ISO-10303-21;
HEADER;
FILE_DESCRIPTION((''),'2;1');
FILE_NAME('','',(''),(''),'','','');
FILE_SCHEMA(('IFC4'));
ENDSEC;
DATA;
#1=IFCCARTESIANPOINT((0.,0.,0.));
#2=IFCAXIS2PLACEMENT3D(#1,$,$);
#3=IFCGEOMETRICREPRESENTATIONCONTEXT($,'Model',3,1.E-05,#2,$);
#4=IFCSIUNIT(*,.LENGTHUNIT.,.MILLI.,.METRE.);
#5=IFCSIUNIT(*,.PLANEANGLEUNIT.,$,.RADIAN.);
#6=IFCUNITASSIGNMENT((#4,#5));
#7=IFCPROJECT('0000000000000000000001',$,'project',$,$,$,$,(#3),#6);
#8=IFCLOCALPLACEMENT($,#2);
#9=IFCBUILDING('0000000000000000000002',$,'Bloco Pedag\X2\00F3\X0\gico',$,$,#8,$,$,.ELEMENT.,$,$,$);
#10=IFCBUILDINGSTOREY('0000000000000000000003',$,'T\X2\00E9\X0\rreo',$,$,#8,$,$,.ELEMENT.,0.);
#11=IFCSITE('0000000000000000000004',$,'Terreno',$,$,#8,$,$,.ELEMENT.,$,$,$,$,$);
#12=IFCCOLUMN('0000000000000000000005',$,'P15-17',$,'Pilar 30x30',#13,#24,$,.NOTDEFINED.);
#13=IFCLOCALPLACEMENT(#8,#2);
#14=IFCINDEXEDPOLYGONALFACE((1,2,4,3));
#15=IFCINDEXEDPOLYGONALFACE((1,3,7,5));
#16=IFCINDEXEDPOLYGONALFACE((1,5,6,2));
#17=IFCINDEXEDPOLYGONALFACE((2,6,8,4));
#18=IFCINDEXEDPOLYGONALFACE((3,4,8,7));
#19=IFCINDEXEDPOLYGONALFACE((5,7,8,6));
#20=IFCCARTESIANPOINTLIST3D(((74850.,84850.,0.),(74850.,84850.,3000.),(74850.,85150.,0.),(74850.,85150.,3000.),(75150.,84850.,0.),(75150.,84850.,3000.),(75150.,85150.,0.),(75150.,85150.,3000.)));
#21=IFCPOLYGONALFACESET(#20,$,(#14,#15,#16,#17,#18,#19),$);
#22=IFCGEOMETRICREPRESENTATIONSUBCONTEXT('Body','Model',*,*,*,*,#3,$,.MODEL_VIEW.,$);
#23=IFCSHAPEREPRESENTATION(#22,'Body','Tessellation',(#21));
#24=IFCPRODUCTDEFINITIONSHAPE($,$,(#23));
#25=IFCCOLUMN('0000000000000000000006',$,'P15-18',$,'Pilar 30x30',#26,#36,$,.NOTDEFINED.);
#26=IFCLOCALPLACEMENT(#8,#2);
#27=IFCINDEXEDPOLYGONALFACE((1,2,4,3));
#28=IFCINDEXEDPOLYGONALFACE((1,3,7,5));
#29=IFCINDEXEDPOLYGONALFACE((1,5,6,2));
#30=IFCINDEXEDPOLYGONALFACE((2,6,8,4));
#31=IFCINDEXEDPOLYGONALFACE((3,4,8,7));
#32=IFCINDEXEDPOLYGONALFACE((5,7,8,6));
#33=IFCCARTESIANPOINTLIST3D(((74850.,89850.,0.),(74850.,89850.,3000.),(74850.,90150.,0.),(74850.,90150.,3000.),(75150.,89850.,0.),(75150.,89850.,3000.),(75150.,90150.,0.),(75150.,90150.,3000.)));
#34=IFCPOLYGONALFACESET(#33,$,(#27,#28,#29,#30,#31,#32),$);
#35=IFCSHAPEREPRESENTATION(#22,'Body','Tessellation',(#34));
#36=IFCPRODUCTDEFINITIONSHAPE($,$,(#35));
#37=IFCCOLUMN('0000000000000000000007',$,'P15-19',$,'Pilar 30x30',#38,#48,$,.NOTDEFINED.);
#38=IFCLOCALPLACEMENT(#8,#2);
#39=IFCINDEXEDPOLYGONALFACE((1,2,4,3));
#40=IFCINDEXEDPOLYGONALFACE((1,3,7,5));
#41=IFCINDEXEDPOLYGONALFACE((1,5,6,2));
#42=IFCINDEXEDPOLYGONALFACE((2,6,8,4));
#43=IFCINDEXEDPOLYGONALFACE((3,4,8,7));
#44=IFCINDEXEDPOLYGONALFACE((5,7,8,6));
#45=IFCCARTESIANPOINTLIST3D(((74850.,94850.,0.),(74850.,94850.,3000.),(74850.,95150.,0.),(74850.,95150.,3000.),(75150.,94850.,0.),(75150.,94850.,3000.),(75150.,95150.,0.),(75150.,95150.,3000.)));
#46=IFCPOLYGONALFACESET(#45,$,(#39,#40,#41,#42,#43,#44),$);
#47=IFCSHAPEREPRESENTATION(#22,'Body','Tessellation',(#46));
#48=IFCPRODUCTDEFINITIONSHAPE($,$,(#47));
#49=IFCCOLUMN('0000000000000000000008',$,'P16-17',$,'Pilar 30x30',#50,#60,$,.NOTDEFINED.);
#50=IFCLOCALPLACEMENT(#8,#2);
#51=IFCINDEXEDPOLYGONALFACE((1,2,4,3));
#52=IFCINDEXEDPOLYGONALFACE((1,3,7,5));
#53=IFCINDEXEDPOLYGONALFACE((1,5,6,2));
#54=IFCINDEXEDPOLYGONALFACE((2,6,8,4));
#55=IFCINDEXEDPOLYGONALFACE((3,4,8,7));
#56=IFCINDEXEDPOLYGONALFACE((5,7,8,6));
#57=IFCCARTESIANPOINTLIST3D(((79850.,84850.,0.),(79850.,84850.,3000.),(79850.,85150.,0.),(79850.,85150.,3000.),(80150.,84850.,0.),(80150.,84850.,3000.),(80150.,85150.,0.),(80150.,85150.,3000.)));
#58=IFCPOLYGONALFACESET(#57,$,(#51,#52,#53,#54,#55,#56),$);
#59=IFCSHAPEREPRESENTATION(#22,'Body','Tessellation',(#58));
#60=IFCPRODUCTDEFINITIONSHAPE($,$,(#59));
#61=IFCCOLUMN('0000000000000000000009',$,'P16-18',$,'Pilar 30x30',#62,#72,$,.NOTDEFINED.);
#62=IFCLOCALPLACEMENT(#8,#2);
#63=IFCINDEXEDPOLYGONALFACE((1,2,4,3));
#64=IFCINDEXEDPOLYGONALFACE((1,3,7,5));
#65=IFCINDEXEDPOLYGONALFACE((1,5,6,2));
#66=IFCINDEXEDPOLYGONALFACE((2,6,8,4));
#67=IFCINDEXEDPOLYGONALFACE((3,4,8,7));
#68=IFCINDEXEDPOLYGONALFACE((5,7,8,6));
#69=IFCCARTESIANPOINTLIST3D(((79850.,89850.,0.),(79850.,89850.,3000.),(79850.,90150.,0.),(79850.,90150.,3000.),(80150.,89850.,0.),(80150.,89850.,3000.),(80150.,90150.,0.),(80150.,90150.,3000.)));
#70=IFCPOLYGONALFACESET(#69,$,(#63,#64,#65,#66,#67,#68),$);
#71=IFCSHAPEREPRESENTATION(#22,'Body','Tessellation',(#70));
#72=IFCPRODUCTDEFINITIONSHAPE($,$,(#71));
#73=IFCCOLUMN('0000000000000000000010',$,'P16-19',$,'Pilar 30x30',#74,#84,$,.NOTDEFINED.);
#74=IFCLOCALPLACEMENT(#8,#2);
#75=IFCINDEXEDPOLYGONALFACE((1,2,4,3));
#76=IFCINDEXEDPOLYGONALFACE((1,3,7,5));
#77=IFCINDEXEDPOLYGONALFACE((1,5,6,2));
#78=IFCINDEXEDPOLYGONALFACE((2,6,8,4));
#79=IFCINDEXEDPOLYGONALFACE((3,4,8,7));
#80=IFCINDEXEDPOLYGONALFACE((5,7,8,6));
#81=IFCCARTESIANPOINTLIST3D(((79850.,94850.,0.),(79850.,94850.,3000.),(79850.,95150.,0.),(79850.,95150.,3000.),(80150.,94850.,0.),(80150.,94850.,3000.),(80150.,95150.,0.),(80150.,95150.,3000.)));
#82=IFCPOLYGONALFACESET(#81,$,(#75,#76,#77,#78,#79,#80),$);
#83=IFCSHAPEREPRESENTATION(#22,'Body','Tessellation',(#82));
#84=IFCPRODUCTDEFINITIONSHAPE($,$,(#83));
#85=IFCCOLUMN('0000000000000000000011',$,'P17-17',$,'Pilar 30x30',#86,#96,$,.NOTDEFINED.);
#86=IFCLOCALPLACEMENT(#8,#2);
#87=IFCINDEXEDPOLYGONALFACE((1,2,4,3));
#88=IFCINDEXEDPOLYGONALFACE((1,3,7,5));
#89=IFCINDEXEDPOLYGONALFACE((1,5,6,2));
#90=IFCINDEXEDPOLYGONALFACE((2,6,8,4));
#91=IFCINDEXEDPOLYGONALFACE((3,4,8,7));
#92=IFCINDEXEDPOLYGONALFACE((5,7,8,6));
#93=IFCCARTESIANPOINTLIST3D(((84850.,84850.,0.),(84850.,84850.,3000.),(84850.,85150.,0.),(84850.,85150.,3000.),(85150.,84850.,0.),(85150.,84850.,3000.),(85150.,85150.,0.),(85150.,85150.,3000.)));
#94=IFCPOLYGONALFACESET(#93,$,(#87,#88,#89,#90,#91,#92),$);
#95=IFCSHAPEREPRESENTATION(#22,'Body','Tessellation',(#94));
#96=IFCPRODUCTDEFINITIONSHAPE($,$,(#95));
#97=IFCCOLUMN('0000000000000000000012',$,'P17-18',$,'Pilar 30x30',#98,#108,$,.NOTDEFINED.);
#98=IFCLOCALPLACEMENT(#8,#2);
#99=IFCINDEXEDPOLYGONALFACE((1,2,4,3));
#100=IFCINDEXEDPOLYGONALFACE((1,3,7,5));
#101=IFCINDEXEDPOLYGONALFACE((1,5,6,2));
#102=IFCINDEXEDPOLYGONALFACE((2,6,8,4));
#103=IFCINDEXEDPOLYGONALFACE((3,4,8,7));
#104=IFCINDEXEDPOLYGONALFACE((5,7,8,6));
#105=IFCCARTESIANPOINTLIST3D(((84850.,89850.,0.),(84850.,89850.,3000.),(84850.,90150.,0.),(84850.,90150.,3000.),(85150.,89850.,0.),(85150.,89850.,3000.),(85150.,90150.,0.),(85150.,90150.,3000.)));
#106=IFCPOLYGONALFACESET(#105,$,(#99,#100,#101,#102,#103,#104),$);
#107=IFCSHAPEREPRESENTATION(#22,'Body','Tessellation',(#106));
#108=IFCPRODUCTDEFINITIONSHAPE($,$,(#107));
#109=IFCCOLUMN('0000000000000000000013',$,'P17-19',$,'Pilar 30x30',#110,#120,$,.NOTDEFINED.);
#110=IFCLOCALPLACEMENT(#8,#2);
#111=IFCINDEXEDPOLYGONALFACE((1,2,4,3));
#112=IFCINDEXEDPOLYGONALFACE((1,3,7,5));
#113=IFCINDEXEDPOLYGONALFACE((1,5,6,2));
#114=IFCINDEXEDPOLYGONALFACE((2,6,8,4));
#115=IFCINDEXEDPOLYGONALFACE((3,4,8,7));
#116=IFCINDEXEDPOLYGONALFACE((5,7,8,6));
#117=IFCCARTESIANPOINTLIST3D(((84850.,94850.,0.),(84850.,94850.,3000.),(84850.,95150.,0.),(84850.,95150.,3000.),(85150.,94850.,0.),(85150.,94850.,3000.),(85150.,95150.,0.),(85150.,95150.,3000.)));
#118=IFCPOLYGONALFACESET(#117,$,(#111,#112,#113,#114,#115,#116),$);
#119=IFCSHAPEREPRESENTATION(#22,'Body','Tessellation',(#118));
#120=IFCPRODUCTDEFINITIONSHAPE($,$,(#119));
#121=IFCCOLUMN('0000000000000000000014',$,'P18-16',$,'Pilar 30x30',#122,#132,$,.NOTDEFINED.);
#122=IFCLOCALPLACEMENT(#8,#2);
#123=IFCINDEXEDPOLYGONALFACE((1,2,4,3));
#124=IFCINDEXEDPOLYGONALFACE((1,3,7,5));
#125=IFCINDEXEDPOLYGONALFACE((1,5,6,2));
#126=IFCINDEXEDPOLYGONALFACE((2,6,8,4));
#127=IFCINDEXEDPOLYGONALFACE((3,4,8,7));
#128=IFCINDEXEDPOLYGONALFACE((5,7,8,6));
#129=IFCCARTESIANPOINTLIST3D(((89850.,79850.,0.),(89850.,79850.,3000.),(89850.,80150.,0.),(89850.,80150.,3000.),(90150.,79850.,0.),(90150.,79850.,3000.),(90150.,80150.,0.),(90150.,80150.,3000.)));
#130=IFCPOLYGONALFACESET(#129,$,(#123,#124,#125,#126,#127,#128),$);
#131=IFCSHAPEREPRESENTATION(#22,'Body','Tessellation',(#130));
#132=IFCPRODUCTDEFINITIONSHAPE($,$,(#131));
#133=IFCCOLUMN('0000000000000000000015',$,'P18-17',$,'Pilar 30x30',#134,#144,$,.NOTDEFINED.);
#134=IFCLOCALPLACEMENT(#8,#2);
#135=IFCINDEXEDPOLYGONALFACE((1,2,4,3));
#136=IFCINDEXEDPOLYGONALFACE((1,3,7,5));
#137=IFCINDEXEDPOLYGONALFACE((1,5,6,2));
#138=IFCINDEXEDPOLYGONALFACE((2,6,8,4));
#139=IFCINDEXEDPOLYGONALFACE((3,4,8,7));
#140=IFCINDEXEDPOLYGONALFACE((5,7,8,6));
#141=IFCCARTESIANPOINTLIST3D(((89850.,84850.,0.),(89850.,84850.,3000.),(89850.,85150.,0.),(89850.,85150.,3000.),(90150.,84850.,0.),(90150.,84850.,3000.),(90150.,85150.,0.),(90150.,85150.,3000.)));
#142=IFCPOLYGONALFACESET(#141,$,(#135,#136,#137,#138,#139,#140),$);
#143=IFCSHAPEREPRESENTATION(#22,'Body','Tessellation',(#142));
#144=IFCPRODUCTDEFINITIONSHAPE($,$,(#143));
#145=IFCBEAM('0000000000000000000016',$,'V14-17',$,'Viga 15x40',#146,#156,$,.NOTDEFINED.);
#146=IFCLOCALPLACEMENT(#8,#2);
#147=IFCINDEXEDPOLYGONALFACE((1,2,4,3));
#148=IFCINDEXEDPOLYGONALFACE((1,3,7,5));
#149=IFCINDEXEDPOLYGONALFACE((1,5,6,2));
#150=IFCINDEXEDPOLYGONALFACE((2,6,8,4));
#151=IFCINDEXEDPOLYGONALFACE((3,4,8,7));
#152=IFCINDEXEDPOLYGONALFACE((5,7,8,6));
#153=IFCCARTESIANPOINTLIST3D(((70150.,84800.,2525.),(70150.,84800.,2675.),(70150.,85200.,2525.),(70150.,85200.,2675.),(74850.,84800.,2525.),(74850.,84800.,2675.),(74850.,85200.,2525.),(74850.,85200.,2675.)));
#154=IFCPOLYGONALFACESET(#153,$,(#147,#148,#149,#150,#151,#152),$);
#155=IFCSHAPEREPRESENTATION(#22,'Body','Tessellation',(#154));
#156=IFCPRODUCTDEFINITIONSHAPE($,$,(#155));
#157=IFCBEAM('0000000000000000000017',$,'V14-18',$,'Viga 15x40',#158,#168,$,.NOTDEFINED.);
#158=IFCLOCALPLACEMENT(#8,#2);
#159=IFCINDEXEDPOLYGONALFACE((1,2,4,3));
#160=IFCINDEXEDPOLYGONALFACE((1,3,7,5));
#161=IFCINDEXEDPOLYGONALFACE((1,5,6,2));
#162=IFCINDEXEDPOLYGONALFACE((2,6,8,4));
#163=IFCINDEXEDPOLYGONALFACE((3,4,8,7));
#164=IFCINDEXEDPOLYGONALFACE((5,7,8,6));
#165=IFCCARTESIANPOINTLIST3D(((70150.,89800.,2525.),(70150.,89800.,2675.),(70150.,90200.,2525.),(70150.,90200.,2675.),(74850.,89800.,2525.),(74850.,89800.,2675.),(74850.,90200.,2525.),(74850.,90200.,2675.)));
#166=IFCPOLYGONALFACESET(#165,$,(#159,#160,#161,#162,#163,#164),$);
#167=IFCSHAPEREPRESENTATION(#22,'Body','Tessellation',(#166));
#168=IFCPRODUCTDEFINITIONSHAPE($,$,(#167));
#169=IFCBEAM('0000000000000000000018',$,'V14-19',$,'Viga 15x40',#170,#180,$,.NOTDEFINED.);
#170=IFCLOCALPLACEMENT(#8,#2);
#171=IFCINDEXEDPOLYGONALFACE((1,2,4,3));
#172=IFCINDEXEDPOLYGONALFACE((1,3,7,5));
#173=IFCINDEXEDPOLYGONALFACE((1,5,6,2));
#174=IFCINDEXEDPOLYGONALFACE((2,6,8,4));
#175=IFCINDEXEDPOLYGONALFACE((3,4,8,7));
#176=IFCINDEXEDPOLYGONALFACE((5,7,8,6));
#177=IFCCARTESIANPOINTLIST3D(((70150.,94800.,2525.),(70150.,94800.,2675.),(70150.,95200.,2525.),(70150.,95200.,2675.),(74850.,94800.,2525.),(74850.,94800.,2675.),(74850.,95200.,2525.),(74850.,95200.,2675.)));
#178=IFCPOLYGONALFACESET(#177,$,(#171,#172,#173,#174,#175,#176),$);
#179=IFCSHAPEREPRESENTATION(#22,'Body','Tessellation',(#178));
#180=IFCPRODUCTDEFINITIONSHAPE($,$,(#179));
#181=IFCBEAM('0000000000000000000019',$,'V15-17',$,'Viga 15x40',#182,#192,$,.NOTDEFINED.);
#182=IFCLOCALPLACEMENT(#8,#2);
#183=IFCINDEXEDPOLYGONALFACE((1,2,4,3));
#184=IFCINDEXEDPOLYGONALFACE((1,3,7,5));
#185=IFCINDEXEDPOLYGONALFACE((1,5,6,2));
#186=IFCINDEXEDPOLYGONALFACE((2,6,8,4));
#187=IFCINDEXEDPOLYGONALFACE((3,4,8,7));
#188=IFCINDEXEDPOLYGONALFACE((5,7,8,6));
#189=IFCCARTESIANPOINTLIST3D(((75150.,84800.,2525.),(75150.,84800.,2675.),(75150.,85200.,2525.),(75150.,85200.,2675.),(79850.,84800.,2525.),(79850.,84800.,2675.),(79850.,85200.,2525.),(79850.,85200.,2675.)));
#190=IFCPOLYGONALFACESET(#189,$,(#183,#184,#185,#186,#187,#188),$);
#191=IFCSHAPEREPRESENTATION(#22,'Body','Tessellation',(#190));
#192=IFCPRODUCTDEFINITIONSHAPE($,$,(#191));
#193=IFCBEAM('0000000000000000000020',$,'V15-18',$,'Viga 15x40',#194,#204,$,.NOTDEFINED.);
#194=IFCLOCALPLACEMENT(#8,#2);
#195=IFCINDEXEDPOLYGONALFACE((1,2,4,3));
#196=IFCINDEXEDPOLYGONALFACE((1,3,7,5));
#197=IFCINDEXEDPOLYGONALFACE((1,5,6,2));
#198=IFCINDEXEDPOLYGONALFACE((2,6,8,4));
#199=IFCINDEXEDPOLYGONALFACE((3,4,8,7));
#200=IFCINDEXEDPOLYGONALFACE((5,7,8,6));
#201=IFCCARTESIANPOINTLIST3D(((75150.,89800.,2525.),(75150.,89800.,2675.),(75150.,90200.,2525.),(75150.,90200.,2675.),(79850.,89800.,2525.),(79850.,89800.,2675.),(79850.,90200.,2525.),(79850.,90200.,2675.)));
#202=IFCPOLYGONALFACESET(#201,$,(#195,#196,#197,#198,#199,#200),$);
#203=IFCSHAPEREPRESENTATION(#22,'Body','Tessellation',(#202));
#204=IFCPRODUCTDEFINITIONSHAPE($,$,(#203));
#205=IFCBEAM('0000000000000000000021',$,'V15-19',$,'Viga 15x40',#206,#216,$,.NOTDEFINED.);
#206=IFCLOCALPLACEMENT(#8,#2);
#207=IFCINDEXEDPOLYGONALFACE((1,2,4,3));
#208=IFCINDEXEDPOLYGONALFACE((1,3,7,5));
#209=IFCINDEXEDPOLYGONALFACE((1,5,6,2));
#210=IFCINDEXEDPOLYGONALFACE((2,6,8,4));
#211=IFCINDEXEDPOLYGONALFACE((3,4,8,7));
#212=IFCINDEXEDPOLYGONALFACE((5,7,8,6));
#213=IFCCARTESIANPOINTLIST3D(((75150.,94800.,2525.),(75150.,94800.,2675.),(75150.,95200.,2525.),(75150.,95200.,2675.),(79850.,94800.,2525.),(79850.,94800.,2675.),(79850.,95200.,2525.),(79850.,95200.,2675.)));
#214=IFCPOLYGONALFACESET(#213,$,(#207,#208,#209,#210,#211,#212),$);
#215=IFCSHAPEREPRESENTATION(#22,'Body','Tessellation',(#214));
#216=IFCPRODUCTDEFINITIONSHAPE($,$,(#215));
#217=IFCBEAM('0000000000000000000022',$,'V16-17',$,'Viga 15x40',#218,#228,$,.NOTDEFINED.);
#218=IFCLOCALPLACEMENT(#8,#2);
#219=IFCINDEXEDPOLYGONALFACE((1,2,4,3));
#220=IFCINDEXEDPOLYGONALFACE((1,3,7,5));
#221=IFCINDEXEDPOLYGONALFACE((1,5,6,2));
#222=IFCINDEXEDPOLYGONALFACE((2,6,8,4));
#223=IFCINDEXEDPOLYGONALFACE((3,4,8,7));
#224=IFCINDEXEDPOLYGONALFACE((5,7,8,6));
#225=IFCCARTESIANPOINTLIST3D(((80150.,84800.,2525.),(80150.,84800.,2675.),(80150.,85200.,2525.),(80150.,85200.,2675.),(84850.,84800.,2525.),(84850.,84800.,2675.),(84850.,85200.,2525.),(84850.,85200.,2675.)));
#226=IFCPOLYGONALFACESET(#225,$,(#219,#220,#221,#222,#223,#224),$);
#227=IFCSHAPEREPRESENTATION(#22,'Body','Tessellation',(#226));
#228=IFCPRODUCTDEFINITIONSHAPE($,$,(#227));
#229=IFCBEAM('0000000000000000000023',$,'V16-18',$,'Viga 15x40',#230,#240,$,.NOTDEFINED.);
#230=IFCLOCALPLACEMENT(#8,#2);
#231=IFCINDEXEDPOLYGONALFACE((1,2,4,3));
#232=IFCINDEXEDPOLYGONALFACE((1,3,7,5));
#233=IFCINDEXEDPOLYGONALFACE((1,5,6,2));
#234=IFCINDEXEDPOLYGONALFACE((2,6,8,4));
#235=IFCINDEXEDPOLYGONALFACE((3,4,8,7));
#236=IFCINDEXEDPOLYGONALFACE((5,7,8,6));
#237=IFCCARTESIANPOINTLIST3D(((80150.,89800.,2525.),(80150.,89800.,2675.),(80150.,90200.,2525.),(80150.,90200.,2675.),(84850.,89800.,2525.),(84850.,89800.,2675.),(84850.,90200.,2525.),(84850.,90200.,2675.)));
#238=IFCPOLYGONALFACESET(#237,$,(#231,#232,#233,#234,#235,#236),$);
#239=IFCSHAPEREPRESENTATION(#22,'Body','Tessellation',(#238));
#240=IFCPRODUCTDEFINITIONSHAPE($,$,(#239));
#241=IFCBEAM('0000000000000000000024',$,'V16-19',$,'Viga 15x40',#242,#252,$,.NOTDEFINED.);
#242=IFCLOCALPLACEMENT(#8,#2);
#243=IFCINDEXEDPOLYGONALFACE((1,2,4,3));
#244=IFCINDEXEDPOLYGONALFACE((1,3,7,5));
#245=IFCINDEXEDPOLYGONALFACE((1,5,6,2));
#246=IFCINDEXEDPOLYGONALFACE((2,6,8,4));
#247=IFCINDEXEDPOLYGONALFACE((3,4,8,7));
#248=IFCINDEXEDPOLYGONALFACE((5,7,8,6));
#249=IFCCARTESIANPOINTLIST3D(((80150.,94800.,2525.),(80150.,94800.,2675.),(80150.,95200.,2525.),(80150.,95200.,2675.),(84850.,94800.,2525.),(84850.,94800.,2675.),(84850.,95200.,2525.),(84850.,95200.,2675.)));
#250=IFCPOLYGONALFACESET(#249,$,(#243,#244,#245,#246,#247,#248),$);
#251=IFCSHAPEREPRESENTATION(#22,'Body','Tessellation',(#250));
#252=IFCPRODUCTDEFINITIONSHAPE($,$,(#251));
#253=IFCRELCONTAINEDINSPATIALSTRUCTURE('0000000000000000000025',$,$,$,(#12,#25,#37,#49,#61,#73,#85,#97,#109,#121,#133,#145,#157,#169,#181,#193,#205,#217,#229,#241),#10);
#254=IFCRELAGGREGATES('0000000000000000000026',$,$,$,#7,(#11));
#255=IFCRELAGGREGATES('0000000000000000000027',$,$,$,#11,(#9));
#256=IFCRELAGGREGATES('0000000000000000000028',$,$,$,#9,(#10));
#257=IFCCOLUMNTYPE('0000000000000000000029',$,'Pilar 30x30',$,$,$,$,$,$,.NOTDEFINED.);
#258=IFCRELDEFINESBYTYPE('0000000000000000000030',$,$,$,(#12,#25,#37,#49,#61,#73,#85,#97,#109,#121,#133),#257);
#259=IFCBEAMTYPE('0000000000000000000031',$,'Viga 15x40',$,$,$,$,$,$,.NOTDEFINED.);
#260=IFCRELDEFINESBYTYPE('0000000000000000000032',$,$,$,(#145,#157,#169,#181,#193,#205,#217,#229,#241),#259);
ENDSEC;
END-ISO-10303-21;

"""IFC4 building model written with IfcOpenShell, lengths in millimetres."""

from ifc_helpers import new_model, si_unit, frame, origin, origin_2d, place, context, subcontext, project, spatial, rectangle, extrude, type_object, element, save


model = new_model("IFC4")

# Units and contexts
model_context = context("Model", 3, precision=1e-05, world=origin())
body_context = subcontext(model_context, "Body", "Model", "MODEL_VIEW")
ifc_project = project(units=[si_unit("LENGTHUNIT", "METRE", prefix="MILLI"), si_unit("PLANEANGLEUNIT", "RADIAN")], contexts=[model_context])

# Site, building, storey
placement = place(None, origin())
site = spatial("IfcSite", under=ifc_project, at=placement, Name="Terreno", CompositionType="ELEMENT")
building = spatial("IfcBuilding", under=site, at=placement, Name="Bloco Pedagógico", CompositionType="ELEMENT")
storey = spatial("IfcBuildingStorey", under=building, at=placement, Name="Térreo", CompositionType="ELEMENT", Elevation=0.0)

# Columns
column_type = type_object("IfcColumnType", Name="Pilar 30x30", PredefinedType="NOTDEFINED")
for number, where, z_axis, x_axis, name in (
    (1, (75000.0, 85000.0, 0.0), (0.0, 0.0, 1.0), (1.0, 0.0, 0.0), "P15-17"),
    (2, (75000.0, 90000.0, 0.0), (0.0, 0.0, 1.0), (1.0, 0.0, 0.0), "P15-18"),
    (3, (75000.0, 95000.0, 0.0), (0.0, 0.0, 1.0), (1.0, 0.0, 0.0), "P15-19"),
    (4, (80000.0, 85000.0, 0.0), (0.0, 0.0, 1.0), (1.0, 0.0, 0.0), "P16-17"),
    (5, (80000.0, 90000.0, 0.0), (0.0, 0.0, 1.0), (1.0, 0.0, 0.0), "P16-18"),
    (6, (80000.0, 95000.0, 0.0), (0.0, 0.0, 1.0), (1.0, 0.0, 0.0), "P16-19"),
    (7, (85000.0, 85000.0, 0.0), (0.0, 0.0, 1.0), (1.0, 0.0, 0.0), "P17-17"),
    (8, (85000.0, 90000.0, 0.0), (0.0, 0.0, 1.0), (1.0, 0.0, 0.0), "P17-18"),
    (9, (85000.0, 95000.0, 0.0), (0.0, 0.0, 1.0), (1.0, 0.0, 0.0), "P17-19"),
    (10, (90000.0, 80000.0, 0.0), (0.0, 0.0, 1.0), (1.0, 0.0, 0.0), "P18-16"),
    (11, (90000.0, 85000.0, 0.0), (0.0, 0.0, 1.0), (1.0, 0.0, 0.0), "P18-17"),
):
    element("IfcColumn", number, at=place(None, frame(where, z_axis=z_axis, x_axis=x_axis)), inside=storey, type_object=column_type, Name=name, ObjectType="Pilar 30x30", PredefinedType="NOTDEFINED", context=body_context, shape_type="SweptSolid", body=[
        extrude(rectangle(XDim=300.0, YDim=300.0, at=origin_2d()), None, (0.0, 0.0, 1.0), 3000.0),
    ])

# Beams
beam_type = type_object("IfcBeamType", Name="Viga 15x40", PredefinedType="NOTDEFINED")
for number, where, z_axis, x_axis, name in (
    (12, (70150.0, 85000.0, 2600.0), (1.0, 0.0, 0.0), (0.0, 1.0, 0.0), "V14-17"),
    (13, (70150.0, 90000.0, 2600.0), (1.0, 0.0, 0.0), (0.0, 1.0, 0.0), "V14-18"),
    (14, (70150.0, 95000.0, 2600.0), (1.0, 0.0, 0.0), (0.0, 1.0, 0.0), "V14-19"),
    (15, (75150.0, 85000.0, 2600.0), (1.0, 0.0, 0.0), (0.0, 1.0, 0.0), "V15-17"),
    (16, (75150.0, 90000.0, 2600.0), (1.0, 0.0, 0.0), (0.0, 1.0, 0.0), "V15-18"),
    (17, (75150.0, 95000.0, 2600.0), (1.0, 0.0, 0.0), (0.0, 1.0, 0.0), "V15-19"),
    (18, (80150.0, 85000.0, 2600.0), (1.0, 0.0, 0.0), (0.0, 1.0, 0.0), "V16-17"),
    (19, (80150.0, 90000.0, 2600.0), (1.0, 0.0, 0.0), (0.0, 1.0, 0.0), "V16-18"),
    (20, (80150.0, 95000.0, 2600.0), (1.0, 0.0, 0.0), (0.0, 1.0, 0.0), "V16-19"),
):
    element("IfcBeam", number, at=place(None, frame(where, z_axis=z_axis, x_axis=x_axis)), inside=storey, type_object=beam_type, Name=name, ObjectType="Viga 15x40", PredefinedType="NOTDEFINED", context=body_context, shape_type="SweptSolid", body=[
        extrude(rectangle(XDim=400.0, YDim=150.0, at=origin_2d()), None, (0.0, 0.0, 1.0), 4700.0),
    ])

save(model, "model.ifc")
